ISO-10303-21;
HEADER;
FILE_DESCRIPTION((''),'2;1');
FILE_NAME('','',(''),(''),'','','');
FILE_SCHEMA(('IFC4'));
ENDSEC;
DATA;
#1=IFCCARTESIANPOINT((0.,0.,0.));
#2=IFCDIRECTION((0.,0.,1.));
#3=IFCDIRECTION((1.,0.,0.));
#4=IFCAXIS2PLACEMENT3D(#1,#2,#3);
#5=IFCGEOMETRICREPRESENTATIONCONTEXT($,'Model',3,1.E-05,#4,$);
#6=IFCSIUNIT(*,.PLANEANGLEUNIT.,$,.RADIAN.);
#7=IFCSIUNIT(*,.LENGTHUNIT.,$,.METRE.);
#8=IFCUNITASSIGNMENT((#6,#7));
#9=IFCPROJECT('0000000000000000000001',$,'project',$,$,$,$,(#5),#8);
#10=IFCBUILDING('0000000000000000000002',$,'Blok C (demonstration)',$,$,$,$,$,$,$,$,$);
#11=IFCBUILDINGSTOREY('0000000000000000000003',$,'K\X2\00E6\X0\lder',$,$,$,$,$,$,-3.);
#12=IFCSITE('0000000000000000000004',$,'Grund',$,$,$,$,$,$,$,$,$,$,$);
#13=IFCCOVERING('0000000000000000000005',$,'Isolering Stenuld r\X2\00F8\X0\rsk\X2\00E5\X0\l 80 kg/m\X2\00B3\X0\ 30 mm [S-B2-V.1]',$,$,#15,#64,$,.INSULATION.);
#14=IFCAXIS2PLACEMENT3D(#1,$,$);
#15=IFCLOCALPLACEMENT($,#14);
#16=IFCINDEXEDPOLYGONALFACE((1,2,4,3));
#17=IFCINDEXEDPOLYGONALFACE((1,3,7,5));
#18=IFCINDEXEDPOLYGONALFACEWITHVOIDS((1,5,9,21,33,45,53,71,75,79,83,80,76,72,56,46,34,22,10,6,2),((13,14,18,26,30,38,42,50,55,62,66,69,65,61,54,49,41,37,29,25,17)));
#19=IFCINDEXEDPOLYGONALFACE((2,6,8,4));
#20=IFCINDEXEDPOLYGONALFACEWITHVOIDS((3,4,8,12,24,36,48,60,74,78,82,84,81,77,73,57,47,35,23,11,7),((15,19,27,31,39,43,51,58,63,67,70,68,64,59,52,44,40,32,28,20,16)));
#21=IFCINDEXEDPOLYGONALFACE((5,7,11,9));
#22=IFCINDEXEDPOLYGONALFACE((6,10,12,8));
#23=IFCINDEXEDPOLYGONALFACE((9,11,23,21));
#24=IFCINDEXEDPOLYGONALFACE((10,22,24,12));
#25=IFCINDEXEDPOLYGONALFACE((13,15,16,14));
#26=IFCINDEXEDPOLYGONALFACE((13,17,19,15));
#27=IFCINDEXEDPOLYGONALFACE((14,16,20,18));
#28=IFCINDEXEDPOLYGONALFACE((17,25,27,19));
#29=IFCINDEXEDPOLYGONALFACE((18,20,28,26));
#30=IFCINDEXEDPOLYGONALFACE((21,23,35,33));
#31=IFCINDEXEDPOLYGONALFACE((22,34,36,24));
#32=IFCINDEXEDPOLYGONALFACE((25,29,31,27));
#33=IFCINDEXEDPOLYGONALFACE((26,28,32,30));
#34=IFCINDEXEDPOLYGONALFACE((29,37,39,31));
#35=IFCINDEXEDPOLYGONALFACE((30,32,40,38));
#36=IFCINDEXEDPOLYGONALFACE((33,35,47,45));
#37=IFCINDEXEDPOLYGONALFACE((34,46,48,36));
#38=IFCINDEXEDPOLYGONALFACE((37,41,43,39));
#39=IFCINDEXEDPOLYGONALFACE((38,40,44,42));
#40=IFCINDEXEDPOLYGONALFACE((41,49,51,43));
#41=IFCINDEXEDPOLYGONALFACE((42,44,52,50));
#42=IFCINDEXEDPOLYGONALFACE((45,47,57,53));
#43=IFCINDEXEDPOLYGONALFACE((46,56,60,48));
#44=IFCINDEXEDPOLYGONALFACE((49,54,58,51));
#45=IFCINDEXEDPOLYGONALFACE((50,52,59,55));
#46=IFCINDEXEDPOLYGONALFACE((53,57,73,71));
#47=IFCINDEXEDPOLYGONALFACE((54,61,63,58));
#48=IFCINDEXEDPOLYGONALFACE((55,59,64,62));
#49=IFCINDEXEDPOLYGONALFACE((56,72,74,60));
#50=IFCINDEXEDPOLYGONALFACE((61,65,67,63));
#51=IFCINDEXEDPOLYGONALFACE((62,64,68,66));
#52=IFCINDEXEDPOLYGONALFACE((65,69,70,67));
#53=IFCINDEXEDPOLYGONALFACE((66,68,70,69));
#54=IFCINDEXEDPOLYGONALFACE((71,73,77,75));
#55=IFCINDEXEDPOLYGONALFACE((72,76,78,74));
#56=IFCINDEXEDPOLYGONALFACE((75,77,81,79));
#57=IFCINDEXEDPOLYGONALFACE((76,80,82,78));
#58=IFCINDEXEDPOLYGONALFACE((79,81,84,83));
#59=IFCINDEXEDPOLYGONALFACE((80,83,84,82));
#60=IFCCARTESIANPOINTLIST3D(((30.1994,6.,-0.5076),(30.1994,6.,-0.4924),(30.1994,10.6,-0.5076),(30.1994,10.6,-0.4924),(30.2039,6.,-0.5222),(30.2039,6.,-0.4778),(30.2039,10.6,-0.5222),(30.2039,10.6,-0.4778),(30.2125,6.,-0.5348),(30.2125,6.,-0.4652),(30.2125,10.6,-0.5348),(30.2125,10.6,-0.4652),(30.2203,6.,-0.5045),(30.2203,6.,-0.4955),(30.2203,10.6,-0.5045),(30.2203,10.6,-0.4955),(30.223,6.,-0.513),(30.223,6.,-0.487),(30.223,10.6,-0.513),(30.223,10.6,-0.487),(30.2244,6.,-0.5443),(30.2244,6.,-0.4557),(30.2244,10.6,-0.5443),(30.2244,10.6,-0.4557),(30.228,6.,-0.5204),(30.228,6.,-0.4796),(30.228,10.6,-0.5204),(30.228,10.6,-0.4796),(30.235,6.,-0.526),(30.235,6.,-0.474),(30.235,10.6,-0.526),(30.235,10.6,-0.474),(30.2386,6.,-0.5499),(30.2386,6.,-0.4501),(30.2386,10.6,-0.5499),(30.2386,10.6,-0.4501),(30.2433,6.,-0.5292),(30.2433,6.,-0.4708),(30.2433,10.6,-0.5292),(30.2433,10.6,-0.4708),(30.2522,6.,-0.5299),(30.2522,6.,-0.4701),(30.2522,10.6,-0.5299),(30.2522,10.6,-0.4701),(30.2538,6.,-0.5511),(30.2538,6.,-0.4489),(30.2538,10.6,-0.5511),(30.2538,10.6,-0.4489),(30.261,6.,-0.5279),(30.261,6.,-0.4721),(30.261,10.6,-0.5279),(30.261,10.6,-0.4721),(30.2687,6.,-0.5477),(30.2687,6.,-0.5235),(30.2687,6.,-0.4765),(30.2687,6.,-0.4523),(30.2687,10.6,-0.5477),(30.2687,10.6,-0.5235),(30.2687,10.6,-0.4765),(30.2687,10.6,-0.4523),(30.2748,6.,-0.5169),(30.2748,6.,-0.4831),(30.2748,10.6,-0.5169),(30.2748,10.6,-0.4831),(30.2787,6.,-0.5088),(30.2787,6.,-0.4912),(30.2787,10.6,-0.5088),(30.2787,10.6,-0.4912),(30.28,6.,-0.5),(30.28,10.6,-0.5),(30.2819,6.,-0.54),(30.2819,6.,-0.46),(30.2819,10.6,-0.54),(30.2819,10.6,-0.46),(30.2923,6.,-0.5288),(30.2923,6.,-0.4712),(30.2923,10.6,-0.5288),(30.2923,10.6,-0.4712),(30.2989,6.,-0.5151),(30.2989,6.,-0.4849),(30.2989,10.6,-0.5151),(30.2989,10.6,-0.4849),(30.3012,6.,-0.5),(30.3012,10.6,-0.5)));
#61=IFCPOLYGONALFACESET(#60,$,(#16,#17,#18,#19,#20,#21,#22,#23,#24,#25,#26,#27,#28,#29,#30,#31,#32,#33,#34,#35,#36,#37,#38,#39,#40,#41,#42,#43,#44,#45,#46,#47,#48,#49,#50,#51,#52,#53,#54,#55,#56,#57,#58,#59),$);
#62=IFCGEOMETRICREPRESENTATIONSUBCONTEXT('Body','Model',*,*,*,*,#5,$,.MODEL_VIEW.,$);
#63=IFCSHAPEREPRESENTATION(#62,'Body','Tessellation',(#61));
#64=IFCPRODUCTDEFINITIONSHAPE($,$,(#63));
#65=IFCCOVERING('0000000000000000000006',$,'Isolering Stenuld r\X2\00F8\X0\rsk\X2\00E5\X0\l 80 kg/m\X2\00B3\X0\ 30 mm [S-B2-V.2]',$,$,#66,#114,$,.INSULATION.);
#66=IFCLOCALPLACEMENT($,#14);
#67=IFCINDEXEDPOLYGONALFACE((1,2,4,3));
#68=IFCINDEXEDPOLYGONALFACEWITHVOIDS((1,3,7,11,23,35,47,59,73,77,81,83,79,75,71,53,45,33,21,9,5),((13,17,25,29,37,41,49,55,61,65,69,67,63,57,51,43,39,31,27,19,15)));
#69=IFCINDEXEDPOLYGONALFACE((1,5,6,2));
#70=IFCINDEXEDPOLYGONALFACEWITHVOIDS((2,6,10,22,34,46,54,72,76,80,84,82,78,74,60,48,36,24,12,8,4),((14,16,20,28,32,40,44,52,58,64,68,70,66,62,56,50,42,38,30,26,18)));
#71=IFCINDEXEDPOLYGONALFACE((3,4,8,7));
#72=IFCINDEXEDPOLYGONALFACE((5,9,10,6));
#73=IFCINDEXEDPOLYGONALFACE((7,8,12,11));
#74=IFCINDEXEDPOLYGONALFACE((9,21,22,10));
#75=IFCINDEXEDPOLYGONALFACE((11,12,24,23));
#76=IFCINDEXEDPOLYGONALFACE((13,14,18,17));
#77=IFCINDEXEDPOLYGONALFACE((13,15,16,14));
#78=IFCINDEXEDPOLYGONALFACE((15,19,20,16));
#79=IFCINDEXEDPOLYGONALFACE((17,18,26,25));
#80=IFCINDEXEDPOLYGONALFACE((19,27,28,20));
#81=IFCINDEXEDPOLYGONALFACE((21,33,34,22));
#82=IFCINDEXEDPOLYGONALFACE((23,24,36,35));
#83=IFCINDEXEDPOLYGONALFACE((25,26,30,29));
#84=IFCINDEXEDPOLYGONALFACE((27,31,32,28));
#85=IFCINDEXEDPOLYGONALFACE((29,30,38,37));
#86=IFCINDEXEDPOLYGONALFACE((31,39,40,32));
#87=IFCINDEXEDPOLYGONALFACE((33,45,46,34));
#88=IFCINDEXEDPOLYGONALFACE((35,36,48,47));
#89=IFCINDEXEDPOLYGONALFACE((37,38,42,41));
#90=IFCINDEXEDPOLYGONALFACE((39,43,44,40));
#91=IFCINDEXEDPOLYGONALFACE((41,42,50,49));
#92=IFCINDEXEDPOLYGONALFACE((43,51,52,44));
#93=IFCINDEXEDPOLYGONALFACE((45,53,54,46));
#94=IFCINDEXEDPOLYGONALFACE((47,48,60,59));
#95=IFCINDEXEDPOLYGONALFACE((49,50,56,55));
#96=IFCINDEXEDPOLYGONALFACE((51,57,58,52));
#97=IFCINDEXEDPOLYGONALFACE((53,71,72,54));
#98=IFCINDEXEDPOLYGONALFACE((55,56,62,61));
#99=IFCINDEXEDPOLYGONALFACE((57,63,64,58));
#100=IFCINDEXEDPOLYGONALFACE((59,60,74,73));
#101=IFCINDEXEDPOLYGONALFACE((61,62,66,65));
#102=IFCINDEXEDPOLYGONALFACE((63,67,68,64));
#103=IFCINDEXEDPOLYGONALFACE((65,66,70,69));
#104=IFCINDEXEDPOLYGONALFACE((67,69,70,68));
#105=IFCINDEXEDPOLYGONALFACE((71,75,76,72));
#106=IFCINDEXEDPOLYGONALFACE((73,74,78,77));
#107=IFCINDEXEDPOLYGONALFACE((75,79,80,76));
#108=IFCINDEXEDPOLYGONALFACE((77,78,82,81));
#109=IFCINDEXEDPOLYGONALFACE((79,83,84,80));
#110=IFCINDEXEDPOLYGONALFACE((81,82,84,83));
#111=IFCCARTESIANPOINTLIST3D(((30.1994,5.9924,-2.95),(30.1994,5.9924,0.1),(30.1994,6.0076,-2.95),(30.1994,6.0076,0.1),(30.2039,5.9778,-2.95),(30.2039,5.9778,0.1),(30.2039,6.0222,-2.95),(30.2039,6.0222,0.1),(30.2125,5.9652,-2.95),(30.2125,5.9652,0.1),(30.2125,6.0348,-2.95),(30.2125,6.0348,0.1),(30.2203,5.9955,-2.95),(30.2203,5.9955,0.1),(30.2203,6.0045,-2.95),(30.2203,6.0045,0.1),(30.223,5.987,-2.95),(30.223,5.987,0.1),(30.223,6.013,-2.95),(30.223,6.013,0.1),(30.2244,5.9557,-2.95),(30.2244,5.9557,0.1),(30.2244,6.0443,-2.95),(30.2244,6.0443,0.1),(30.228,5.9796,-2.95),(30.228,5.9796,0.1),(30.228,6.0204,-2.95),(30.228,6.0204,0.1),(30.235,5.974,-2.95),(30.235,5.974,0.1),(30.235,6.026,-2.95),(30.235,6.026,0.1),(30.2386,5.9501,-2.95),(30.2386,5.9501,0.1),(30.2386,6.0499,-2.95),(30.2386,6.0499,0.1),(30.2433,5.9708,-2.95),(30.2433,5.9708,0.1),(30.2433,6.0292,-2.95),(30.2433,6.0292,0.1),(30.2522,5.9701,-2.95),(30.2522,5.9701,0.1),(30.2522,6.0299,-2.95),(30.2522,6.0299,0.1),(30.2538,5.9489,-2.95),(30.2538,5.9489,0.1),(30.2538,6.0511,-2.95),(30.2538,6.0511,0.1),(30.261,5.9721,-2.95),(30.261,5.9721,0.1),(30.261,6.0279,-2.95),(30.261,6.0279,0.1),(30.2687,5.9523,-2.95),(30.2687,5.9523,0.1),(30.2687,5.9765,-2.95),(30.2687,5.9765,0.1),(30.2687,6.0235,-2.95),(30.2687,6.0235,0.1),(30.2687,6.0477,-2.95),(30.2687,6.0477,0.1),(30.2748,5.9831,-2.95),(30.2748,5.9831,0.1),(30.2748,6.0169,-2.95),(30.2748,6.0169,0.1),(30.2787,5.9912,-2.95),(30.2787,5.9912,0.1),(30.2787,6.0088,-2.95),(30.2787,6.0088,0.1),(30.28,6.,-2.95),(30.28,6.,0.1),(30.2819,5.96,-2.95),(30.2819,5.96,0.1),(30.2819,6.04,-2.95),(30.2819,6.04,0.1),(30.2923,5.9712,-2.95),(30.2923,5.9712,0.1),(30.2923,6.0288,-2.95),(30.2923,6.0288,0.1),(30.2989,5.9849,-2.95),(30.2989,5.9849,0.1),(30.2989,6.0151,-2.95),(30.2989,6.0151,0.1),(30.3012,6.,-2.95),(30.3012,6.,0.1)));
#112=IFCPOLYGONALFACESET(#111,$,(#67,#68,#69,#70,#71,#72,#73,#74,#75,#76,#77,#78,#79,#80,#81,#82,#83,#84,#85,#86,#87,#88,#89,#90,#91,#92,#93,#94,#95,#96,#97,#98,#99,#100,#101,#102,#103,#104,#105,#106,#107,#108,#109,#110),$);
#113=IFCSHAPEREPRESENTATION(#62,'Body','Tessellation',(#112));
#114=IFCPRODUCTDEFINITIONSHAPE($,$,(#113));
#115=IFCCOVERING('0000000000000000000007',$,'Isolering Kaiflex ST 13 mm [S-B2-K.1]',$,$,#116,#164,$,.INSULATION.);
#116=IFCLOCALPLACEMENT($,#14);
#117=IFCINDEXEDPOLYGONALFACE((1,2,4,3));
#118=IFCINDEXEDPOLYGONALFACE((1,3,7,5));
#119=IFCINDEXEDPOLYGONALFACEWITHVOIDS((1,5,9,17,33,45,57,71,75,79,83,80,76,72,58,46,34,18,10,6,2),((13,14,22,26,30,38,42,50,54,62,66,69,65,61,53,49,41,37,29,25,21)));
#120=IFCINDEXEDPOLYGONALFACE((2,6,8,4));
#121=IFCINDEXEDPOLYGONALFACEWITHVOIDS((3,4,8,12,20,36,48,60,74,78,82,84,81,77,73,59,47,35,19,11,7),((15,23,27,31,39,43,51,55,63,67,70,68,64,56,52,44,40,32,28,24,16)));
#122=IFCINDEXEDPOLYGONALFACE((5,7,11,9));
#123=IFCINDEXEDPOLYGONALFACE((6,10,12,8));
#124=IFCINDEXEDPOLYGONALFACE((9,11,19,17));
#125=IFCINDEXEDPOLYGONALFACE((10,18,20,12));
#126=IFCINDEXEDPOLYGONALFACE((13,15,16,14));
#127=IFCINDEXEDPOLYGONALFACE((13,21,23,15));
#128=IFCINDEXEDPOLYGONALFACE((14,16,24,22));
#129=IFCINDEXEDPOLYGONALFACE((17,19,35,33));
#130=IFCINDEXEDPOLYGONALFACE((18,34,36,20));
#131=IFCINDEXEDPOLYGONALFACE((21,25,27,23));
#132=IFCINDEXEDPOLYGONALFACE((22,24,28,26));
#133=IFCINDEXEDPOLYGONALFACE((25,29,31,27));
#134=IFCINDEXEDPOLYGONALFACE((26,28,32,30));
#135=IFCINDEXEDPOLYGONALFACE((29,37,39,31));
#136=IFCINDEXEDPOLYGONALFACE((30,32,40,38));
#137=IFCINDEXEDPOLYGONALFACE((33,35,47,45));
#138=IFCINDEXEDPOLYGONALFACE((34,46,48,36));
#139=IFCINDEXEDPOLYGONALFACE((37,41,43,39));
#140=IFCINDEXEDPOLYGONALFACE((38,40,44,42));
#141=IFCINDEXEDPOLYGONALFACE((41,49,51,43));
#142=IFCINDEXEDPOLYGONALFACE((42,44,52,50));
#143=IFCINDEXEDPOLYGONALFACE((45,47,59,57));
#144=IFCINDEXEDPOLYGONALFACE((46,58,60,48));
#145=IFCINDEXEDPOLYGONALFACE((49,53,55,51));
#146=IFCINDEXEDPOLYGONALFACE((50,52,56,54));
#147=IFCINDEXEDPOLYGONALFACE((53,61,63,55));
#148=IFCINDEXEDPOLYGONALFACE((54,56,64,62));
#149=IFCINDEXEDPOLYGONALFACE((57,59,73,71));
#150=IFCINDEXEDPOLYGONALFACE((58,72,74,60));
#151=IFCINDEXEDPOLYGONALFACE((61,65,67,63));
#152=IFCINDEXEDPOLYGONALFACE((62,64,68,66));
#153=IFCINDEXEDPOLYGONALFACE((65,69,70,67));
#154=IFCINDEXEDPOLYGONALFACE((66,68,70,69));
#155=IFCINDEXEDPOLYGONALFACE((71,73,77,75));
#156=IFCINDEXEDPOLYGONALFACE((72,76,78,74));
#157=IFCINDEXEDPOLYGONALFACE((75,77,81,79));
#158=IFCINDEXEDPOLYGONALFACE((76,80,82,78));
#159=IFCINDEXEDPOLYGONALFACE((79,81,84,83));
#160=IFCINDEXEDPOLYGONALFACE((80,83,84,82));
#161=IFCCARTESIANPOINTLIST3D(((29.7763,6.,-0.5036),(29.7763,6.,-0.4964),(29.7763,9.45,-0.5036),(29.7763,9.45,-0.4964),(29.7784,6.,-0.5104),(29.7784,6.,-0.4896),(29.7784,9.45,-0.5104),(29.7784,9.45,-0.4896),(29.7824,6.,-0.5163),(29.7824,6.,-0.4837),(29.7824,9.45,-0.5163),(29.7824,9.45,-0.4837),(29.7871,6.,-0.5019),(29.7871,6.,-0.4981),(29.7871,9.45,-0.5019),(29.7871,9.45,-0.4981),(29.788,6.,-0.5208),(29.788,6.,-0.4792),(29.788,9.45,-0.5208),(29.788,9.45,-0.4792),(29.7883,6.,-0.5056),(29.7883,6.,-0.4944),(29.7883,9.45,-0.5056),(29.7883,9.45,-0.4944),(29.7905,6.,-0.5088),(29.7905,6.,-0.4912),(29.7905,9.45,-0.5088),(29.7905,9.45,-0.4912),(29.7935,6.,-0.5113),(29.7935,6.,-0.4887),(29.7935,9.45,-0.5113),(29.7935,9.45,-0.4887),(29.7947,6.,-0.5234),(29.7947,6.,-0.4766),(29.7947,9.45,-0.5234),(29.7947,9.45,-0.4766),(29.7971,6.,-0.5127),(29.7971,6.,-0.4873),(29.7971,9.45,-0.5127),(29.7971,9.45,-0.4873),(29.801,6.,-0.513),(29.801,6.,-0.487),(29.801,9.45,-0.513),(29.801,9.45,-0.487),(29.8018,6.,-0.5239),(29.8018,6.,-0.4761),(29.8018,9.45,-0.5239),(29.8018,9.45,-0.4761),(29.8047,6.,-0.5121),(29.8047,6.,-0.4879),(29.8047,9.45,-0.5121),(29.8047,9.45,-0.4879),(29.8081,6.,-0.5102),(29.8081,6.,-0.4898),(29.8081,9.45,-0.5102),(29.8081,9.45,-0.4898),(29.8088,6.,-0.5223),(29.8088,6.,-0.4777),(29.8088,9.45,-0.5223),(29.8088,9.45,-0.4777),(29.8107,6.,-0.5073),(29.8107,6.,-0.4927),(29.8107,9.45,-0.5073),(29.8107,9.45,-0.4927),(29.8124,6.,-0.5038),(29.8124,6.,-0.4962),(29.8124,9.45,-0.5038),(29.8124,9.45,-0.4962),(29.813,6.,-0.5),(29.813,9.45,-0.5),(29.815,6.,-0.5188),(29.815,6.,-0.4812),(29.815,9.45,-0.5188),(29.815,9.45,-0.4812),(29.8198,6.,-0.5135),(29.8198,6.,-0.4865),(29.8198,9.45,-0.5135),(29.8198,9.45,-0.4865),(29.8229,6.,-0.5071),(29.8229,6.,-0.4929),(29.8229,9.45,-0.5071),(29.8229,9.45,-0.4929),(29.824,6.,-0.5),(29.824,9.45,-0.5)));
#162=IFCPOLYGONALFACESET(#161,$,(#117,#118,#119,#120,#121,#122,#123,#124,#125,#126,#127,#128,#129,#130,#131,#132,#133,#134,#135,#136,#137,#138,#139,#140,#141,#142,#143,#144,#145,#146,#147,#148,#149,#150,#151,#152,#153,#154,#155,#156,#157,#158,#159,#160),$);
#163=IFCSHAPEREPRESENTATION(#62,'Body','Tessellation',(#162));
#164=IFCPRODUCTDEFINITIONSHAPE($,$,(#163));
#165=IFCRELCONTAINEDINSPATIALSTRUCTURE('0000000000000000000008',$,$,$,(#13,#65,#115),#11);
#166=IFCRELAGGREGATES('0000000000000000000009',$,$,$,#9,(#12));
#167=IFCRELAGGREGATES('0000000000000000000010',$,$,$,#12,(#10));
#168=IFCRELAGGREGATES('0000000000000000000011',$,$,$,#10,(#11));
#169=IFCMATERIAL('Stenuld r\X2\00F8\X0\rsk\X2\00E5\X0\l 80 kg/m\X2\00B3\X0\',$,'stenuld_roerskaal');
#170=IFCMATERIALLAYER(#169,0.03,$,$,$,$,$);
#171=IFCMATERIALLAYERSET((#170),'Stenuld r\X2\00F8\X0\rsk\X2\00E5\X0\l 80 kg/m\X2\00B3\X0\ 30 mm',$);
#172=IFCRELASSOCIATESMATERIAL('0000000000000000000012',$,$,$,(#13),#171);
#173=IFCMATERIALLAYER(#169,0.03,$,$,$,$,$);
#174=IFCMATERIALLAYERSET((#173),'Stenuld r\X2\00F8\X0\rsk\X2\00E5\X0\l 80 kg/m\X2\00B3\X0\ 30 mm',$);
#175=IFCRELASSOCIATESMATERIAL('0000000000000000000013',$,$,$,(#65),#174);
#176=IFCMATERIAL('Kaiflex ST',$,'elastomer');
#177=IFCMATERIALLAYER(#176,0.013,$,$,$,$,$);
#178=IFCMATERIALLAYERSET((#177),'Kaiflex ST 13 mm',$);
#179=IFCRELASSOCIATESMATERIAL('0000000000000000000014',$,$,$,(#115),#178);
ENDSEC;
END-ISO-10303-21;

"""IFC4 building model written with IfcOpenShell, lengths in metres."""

from ifc_helpers import new_model, si_unit, frame, origin_with_axes, place, context, subcontext, project, spatial, hollow_circle, extrude, material, layer, layer_set, element, save


model = new_model("IFC4")

# Units and contexts
model_context = context("Model", 3, precision=1e-05, world=origin_with_axes())
body_context = subcontext(model_context, "Body", "Model", "MODEL_VIEW")
ifc_project = project(units=[si_unit("PLANEANGLEUNIT", "RADIAN"), si_unit("LENGTHUNIT", "METRE")], contexts=[model_context])

# Site, building, storey
site = spatial("IfcSite", under=ifc_project, Name="Grund")
building = spatial("IfcBuilding", under=site, Name="Blok C (demonstration)")
storey = spatial("IfcBuildingStorey", under=building, Name="Kælder", Elevation=-3.0)

# Coverings
ifc_material_1 = material(Name="Stenuld rørskål 80 kg/m³", Category="stenuld_roerskaal")
ifc_material_2 = material(Name="Kaiflex ST", Category="elastomer")
ifc_layer_1 = layer(ifc_material_1, 0.03)
ifc_layer_set_1 = layer_set([ifc_layer_1], Name="Stenuld rørskål 80 kg/m³ 30 mm")
covering_1_placement = place(None, origin_with_axes())
element("IfcCovering", 1, at=covering_1_placement, inside=storey, material=ifc_layer_set_1, Name="Isolering Stenuld rørskål 80 kg/m³ 30 mm [S-B2-V.1]", PredefinedType="INSULATION", context=body_context, shape_type="SweptSolid", body=[
    extrude(hollow_circle(Radius=0.0512, WallThickness=0.0212), frame((30.25, 10.6, -0.5), z_axis=(0.0, -1.0, 0.0), x_axis=(1.0, 0.0, 0.0)), (0.0, 0.0, 1.0), 4.6),
])
ifc_layer_2 = layer(ifc_material_1, 0.03)
ifc_layer_set_2 = layer_set([ifc_layer_2], Name="Stenuld rørskål 80 kg/m³ 30 mm")
covering_2_placement = place(None, origin_with_axes())
element("IfcCovering", 2, at=covering_2_placement, inside=storey, material=ifc_layer_set_2, Name="Isolering Stenuld rørskål 80 kg/m³ 30 mm [S-B2-V.2]", PredefinedType="INSULATION", context=body_context, shape_type="SweptSolid", body=[
    extrude(hollow_circle(Radius=0.0512, WallThickness=0.0212), frame((30.25, 6.0, -2.95), z_axis=(0.0, 0.0, 1.0), x_axis=(1.0, 0.0, 0.0)), (0.0, 0.0, 1.0), 3.05),
])
ifc_layer_3 = layer(ifc_material_2, 0.013)
ifc_layer_set_3 = layer_set([ifc_layer_3], Name="Kaiflex ST 13 mm")
covering_3_placement = place(None, origin_with_axes())
element("IfcCovering", 3, at=covering_3_placement, inside=storey, material=ifc_layer_set_3, Name="Isolering Kaiflex ST 13 mm [S-B2-K.1]", PredefinedType="INSULATION", context=body_context, shape_type="SweptSolid", body=[
    extrude(hollow_circle(Radius=0.024, WallThickness=0.011), frame((29.8, 9.45, -0.5), z_axis=(0.0, -1.0, 0.0), x_axis=(1.0, 0.0, 0.0)), (0.0, 0.0, 1.0), 3.45),
])

save(model, "model.ifc")
